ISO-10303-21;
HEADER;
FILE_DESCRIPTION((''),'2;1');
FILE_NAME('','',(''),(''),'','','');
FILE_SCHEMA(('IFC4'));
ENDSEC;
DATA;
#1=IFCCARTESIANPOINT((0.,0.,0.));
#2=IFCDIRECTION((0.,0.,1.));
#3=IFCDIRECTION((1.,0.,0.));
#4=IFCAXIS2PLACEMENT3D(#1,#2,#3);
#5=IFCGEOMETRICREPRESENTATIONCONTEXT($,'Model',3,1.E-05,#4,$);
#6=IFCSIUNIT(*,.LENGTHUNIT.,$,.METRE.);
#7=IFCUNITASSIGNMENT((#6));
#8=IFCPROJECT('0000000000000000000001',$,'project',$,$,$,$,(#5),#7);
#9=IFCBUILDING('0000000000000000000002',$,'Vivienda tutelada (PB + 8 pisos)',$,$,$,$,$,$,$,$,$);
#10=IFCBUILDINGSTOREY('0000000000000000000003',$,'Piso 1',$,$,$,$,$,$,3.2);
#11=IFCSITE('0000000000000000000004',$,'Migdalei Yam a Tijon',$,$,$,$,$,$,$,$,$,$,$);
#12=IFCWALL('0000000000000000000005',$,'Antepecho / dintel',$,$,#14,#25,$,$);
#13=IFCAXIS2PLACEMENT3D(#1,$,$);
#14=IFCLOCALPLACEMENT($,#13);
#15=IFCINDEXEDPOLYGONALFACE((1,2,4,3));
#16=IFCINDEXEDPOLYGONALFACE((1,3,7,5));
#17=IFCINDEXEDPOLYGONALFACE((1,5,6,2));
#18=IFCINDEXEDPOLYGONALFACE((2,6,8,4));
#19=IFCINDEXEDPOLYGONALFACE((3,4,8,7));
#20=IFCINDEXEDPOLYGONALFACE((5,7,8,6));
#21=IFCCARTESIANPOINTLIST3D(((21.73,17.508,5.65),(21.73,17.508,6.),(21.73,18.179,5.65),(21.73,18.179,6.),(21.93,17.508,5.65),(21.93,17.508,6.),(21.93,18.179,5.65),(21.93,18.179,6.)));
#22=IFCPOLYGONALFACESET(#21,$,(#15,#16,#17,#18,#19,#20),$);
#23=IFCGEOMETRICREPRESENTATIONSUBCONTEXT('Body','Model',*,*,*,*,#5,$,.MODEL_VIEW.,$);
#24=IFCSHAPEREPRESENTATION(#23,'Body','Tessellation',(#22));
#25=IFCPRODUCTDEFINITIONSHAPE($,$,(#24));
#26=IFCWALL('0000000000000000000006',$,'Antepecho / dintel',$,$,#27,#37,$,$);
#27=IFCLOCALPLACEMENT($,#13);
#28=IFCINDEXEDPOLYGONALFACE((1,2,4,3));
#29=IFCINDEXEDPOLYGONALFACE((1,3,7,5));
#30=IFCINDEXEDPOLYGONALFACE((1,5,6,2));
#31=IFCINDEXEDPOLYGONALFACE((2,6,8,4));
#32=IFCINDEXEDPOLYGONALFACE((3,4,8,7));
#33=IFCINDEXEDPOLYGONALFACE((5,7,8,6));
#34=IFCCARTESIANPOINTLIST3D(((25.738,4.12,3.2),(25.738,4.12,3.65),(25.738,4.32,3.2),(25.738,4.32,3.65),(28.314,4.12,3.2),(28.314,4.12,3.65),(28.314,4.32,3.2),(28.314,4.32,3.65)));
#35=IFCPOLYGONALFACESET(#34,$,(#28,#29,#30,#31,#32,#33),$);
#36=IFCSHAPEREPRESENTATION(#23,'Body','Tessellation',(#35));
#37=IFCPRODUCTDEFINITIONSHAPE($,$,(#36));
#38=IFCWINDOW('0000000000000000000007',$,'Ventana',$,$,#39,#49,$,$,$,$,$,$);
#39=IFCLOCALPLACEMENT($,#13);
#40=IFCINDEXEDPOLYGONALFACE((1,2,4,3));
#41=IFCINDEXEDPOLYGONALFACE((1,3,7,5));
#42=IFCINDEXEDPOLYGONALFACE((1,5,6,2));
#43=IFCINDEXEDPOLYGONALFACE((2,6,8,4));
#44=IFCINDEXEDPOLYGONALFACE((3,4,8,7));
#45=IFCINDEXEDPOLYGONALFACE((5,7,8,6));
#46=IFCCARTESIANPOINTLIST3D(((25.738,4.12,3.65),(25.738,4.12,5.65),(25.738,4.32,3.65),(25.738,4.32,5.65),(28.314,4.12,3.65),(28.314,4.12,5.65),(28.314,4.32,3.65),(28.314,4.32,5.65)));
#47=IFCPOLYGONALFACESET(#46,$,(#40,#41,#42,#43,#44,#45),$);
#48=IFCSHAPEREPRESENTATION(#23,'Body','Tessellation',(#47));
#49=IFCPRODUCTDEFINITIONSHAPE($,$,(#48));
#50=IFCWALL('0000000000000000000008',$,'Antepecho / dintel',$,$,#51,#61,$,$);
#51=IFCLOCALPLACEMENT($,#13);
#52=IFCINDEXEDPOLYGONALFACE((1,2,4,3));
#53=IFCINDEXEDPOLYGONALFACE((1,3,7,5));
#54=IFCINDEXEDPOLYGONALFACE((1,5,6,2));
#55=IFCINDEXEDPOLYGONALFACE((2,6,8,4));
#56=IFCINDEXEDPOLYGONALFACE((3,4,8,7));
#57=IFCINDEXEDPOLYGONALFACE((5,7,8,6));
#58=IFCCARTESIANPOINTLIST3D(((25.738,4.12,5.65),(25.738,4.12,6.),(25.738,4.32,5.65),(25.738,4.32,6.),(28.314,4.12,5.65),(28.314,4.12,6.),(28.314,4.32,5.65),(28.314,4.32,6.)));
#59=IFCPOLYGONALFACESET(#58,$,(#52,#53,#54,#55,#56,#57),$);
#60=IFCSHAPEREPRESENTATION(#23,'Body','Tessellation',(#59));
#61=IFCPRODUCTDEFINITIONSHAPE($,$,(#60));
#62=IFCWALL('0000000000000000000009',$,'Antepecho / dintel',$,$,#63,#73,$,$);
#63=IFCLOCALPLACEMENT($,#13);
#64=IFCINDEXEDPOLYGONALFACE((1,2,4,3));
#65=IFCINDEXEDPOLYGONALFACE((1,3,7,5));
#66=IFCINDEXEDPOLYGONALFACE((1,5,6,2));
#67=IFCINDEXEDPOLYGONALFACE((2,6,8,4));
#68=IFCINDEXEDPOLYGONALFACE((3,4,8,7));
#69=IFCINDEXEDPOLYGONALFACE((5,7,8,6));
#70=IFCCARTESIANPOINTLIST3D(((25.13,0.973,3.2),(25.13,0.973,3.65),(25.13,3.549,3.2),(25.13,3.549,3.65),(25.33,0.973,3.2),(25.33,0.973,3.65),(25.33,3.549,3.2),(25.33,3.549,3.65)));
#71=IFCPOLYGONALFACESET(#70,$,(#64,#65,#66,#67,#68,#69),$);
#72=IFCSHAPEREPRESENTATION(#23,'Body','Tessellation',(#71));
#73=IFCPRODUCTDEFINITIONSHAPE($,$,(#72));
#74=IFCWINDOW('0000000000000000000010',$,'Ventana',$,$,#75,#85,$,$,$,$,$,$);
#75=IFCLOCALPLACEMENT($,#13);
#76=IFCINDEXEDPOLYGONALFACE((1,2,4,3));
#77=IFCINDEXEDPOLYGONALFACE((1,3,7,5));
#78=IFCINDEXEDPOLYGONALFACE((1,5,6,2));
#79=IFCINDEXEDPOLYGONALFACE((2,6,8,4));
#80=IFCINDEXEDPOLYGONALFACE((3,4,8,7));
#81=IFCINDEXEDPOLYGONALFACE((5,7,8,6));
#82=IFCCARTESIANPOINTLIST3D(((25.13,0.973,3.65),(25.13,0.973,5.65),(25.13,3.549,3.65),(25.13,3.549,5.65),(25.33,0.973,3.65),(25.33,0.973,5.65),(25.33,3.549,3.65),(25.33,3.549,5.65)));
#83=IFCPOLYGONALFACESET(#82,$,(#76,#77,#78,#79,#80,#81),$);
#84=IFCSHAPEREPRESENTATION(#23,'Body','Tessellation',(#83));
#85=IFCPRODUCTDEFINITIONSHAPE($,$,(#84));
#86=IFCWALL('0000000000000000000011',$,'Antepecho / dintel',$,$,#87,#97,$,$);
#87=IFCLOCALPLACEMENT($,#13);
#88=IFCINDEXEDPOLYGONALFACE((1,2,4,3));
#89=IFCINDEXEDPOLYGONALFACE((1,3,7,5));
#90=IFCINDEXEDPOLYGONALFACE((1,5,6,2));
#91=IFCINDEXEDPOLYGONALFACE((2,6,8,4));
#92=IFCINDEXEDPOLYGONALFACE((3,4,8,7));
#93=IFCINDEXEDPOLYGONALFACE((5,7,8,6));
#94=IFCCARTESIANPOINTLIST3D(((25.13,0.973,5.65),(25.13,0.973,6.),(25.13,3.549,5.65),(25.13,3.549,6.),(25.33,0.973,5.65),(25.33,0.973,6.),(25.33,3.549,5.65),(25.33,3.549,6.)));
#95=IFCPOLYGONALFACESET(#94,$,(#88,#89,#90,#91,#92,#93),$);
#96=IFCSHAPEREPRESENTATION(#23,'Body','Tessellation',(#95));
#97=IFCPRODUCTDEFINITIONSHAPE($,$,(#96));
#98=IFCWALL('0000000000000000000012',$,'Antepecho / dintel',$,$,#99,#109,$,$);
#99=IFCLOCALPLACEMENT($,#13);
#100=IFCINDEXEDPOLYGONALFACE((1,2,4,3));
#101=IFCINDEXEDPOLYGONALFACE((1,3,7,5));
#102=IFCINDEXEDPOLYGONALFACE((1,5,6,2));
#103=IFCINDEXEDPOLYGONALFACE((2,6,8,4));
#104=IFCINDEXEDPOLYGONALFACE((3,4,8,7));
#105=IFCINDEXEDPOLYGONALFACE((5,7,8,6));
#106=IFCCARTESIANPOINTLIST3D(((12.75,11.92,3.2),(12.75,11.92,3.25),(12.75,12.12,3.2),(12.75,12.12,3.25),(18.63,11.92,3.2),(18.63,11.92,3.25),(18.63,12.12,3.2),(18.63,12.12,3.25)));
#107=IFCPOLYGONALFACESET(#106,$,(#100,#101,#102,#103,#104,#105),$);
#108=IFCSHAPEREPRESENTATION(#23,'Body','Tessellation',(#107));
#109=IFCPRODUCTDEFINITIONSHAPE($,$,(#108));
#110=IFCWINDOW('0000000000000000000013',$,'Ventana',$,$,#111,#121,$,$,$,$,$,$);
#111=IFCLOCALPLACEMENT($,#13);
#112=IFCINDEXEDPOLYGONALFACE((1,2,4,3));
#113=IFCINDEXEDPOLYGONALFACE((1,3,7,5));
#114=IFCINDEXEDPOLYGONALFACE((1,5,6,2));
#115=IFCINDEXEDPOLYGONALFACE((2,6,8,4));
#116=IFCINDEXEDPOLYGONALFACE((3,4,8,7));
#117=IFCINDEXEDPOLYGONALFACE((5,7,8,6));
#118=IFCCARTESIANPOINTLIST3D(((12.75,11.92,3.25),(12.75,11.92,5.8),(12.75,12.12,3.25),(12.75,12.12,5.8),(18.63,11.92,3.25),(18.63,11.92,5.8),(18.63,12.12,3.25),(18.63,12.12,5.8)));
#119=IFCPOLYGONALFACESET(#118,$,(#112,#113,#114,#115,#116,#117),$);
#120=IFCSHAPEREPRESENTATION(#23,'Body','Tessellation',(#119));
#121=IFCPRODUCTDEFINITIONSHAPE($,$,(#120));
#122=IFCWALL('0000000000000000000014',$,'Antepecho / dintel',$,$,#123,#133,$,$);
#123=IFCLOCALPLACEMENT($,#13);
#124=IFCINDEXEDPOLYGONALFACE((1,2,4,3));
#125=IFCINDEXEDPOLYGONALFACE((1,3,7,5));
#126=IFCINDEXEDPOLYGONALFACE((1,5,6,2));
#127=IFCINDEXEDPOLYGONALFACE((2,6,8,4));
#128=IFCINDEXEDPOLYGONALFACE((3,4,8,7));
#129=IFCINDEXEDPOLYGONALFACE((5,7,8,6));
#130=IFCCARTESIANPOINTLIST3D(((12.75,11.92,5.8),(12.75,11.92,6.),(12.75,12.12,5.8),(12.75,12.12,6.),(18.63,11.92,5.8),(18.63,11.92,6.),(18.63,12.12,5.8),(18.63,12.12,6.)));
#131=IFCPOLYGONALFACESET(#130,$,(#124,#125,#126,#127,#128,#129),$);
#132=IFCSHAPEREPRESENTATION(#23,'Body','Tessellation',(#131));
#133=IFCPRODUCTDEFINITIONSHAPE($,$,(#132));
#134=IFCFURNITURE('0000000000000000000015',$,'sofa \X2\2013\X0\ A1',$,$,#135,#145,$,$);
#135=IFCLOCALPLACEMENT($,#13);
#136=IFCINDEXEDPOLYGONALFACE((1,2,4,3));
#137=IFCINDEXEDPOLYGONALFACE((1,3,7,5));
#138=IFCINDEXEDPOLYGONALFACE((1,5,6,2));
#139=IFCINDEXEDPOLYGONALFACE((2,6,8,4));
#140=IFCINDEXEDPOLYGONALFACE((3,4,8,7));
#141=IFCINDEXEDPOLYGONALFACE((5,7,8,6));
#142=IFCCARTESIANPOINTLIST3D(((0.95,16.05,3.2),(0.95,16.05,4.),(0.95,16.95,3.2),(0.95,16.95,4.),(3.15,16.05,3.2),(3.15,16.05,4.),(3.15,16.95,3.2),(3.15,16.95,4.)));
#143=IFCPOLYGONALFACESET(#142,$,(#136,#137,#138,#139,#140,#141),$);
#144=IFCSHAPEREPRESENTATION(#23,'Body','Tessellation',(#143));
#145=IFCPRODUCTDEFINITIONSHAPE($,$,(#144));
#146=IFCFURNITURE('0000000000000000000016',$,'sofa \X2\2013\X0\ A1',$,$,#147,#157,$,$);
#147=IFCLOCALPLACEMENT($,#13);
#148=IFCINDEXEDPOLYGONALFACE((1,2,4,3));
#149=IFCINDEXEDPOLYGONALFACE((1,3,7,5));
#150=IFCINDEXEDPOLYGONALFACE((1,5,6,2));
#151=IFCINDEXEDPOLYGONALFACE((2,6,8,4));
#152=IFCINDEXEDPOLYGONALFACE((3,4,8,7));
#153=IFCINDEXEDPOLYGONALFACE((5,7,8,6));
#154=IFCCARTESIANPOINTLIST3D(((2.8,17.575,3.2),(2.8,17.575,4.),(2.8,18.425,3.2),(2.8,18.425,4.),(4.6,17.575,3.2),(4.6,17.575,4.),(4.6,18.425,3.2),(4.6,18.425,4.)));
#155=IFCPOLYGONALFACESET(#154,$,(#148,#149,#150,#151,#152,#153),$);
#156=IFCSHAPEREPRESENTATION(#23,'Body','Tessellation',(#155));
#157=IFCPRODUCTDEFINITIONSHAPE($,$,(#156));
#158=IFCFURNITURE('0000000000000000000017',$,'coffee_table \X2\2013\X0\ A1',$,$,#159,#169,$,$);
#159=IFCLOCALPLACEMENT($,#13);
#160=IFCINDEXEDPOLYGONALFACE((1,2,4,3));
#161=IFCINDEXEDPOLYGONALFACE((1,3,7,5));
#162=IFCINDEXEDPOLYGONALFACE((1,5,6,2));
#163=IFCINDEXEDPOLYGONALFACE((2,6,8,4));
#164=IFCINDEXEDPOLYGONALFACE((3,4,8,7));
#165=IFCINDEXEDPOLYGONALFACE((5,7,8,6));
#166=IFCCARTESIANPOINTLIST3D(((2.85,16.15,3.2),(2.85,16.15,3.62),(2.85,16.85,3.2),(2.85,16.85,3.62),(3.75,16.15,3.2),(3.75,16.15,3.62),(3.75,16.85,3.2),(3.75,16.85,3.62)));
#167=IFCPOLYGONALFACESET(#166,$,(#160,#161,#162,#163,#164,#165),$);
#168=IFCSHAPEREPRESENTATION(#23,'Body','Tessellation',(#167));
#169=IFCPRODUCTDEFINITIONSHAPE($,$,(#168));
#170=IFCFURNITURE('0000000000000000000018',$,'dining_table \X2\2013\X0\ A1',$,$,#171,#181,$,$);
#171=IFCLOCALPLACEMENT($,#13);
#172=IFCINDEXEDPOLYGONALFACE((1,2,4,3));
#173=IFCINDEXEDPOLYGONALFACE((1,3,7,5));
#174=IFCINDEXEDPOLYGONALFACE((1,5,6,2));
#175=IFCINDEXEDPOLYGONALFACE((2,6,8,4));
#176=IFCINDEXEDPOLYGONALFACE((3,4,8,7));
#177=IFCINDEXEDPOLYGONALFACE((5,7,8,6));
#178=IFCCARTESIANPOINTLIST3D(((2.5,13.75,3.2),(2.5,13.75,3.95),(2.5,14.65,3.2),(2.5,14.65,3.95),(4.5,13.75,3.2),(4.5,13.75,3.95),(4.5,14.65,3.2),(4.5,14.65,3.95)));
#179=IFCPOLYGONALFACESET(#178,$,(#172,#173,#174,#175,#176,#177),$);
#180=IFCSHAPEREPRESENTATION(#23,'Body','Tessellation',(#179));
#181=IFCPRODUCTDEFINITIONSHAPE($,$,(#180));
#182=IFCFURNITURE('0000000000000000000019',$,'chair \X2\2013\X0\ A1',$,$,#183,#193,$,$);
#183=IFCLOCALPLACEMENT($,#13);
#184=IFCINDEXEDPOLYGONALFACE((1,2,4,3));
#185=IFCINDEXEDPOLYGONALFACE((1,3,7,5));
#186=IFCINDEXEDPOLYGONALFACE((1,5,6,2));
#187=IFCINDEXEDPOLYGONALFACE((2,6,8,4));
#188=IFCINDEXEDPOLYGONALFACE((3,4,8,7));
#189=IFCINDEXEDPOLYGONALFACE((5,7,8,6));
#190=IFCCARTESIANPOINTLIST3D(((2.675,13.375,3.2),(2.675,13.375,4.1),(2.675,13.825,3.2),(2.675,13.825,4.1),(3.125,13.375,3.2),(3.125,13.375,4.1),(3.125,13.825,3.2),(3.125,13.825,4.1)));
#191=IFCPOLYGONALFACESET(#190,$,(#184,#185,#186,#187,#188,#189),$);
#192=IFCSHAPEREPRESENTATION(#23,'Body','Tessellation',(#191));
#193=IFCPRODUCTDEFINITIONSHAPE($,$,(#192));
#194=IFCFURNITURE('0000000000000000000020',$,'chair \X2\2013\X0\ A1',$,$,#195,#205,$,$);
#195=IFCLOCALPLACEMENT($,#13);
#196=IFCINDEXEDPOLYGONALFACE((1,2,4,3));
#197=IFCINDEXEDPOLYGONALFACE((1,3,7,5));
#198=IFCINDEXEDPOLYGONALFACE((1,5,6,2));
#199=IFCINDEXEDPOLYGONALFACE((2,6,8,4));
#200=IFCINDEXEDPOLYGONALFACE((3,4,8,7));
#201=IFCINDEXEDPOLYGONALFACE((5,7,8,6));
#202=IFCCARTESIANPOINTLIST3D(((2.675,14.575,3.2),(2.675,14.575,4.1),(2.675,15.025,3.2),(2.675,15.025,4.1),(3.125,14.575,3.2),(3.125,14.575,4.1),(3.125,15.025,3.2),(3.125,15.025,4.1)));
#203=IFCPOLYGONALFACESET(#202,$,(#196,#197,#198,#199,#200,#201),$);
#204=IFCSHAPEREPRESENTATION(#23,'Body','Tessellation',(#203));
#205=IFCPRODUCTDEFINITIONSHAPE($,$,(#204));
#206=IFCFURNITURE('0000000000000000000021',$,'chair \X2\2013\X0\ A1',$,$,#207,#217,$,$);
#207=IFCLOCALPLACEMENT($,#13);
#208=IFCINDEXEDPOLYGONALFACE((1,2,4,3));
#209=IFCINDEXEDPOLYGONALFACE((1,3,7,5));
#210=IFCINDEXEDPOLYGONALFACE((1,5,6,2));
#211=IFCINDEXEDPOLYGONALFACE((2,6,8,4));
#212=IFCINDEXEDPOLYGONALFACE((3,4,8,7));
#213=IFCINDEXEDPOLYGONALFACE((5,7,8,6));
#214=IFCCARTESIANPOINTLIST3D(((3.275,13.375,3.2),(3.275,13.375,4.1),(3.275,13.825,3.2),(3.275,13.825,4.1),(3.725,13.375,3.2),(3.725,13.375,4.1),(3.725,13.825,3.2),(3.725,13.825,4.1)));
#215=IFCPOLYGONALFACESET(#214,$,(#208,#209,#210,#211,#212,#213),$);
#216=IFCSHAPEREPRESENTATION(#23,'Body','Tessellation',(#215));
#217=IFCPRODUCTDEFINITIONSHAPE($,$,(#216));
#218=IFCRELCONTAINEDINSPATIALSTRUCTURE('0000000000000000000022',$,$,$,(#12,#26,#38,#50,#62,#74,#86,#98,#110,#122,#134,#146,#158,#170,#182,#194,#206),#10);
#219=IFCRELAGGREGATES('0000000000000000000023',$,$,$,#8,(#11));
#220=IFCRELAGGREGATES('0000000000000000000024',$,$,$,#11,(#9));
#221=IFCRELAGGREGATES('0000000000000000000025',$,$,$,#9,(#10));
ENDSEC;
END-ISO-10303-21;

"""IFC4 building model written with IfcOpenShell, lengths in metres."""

from ifc_helpers import new_model, si_unit, frame, origin_with_axes, context, subcontext, project, spatial, line, indexed_curve, outline, extrude, element, save


model = new_model("IFC4")

# Units and contexts
model_context = context("Model", 3, precision=1e-05, world=origin_with_axes())
body_context = subcontext(model_context, "Body", "Model", "MODEL_VIEW")
ifc_project = project(units=[si_unit("LENGTHUNIT", "METRE")], contexts=[model_context])

# Site, building, storey
site = spatial("IfcSite", under=ifc_project, Name="Migdalei Yam a Tijon")
building = spatial("IfcBuilding", under=site, Name="Vivienda tutelada (PB + 8 pisos)")
storey = spatial("IfcBuildingStorey", under=building, Name="Piso 1", Elevation=3.2)

# Walls
element("IfcWall", 1, inside=storey, Name="Antepecho / dintel", context=body_context, shape_type="SweptSolid", body=[
    extrude(outline(indexed_curve([(0.0, 0.0), (0.2, 0.0), (0.2, 0.671), (0.0, 0.671)], segments=[line(1, 2, 3, 4, 1)])), frame((21.73, 17.508, 5.65), z_axis=(0.0, 0.0, 1.0), x_axis=(1.0, 0.0, 0.0)), (0.0, 0.0, 1.0), 0.35),
])
element("IfcWall", 2, inside=storey, Name="Antepecho / dintel", context=body_context, shape_type="SweptSolid", body=[
    extrude(outline(indexed_curve([(0.0, 0.0), (2.576, 0.0), (2.576, 0.2), (0.0, 0.2)], segments=[line(1, 2, 3, 4, 1)])), frame((25.738, 4.12, 3.2), z_axis=(0.0, 0.0, 1.0), x_axis=(1.0, 0.0, 0.0)), (0.0, 0.0, 1.0), 0.45),
])

# Window
element("IfcWindow", 3, inside=storey, Name="Ventana", context=body_context, shape_type="SweptSolid", body=[
    extrude(outline(indexed_curve([(0.0, 0.0), (2.576, 0.0), (2.576, 0.2), (0.0, 0.2)], segments=[line(1, 2, 3, 4, 1)])), frame((25.738, 4.12, 3.65), z_axis=(0.0, 0.0, 1.0), x_axis=(1.0, 0.0, 0.0)), (0.0, 0.0, 1.0), 2.0),
])

# Walls
element("IfcWall", 4, inside=storey, Name="Antepecho / dintel", context=body_context, shape_type="SweptSolid", body=[
    extrude(outline(indexed_curve([(0.0, 0.0), (2.576, 0.0), (2.576, 0.2), (0.0, 0.2)], segments=[line(1, 2, 3, 4, 1)])), frame((25.738, 4.12, 5.65), z_axis=(0.0, 0.0, 1.0), x_axis=(1.0, 0.0, 0.0)), (0.0, 0.0, 1.0), 0.35),
])
element("IfcWall", 5, inside=storey, Name="Antepecho / dintel", context=body_context, shape_type="SweptSolid", body=[
    extrude(outline(indexed_curve([(0.0, 0.0), (0.2, 0.0), (0.2, 2.576), (0.0, 2.576)], segments=[line(1, 2, 3, 4, 1)])), frame((25.13, 0.973, 3.2), z_axis=(0.0, 0.0, 1.0), x_axis=(1.0, 0.0, 0.0)), (0.0, 0.0, 1.0), 0.45),
])

# Window
element("IfcWindow", 6, inside=storey, Name="Ventana", context=body_context, shape_type="SweptSolid", body=[
    extrude(outline(indexed_curve([(0.0, 0.0), (0.2, 0.0), (0.2, 2.576), (0.0, 2.576)], segments=[line(1, 2, 3, 4, 1)])), frame((25.13, 0.973, 3.65), z_axis=(0.0, 0.0, 1.0), x_axis=(1.0, 0.0, 0.0)), (0.0, 0.0, 1.0), 2.0),
])

# Walls
element("IfcWall", 7, inside=storey, Name="Antepecho / dintel", context=body_context, shape_type="SweptSolid", body=[
    extrude(outline(indexed_curve([(0.0, 0.0), (0.2, 0.0), (0.2, 2.576), (0.0, 2.576)], segments=[line(1, 2, 3, 4, 1)])), frame((25.13, 0.973, 5.65), z_axis=(0.0, 0.0, 1.0), x_axis=(1.0, 0.0, 0.0)), (0.0, 0.0, 1.0), 0.35),
])
element("IfcWall", 8, inside=storey, Name="Antepecho / dintel", context=body_context, shape_type="SweptSolid", body=[
    extrude(outline(indexed_curve([(0.0, 0.0), (5.88, 0.0), (5.88, 0.2), (0.0, 0.2)], segments=[line(1, 2, 3, 4, 1)])), frame((12.75, 11.92, 3.2), z_axis=(0.0, 0.0, 1.0), x_axis=(1.0, 0.0, 0.0)), (0.0, 0.0, 1.0), 0.05),
])

# Window
element("IfcWindow", 9, inside=storey, Name="Ventana", context=body_context, shape_type="SweptSolid", body=[
    extrude(outline(indexed_curve([(0.0, 0.0), (5.88, 0.0), (5.88, 0.2), (0.0, 0.2)], segments=[line(1, 2, 3, 4, 1)])), frame((12.75, 11.92, 3.25), z_axis=(0.0, 0.0, 1.0), x_axis=(1.0, 0.0, 0.0)), (0.0, 0.0, 1.0), 2.55),
])

# Wall
element("IfcWall", 10, inside=storey, Name="Antepecho / dintel", context=body_context, shape_type="SweptSolid", body=[
    extrude(outline(indexed_curve([(0.0, 0.0), (5.88, 0.0), (5.88, 0.2), (0.0, 0.2)], segments=[line(1, 2, 3, 4, 1)])), frame((12.75, 11.92, 5.8), z_axis=(0.0, 0.0, 1.0), x_axis=(1.0, 0.0, 0.0)), (0.0, 0.0, 1.0), 0.2),
])

# Furniture
element("IfcFurniture", 11, inside=storey, Name="sofa – A1", context=body_context, shape_type="SweptSolid", body=[
    extrude(outline(indexed_curve([(0.0, 0.0), (2.2, 0.0), (2.2, 0.9), (0.0, 0.9)], segments=[line(1, 2, 3, 4, 1)])), frame((0.95, 16.05, 3.2), z_axis=(0.0, 0.0, 1.0), x_axis=(1.0, 0.0, 0.0)), (0.0, 0.0, 1.0), 0.8),
])
element("IfcFurniture", 12, inside=storey, Name="sofa – A1", context=body_context, shape_type="SweptSolid", body=[
    extrude(outline(indexed_curve([(0.0, 0.0), (1.8, 0.0), (1.8, 0.85), (0.0, 0.85)], segments=[line(1, 2, 3, 4, 1)])), frame((2.8, 17.575, 3.2), z_axis=(0.0, 0.0, 1.0), x_axis=(1.0, 0.0, 0.0)), (0.0, 0.0, 1.0), 0.8),
])
element("IfcFurniture", 13, inside=storey, Name="coffee_table – A1", context=body_context, shape_type="SweptSolid", body=[
    extrude(outline(indexed_curve([(0.0, 0.0), (0.9, 0.0), (0.9, 0.7), (0.0, 0.7)], segments=[line(1, 2, 3, 4, 1)])), frame((2.85, 16.15, 3.2), z_axis=(0.0, 0.0, 1.0), x_axis=(1.0, 0.0, 0.0)), (0.0, 0.0, 1.0), 0.42),
])
element("IfcFurniture", 14, inside=storey, Name="dining_table – A1", context=body_context, shape_type="SweptSolid", body=[
    extrude(outline(indexed_curve([(0.0, 0.0), (2.0, 0.0), (2.0, 0.9), (0.0, 0.9)], segments=[line(1, 2, 3, 4, 1)])), frame((2.5, 13.75, 3.2), z_axis=(0.0, 0.0, 1.0), x_axis=(1.0, 0.0, 0.0)), (0.0, 0.0, 1.0), 0.75),
])
element("IfcFurniture", 15, inside=storey, Name="chair – A1", context=body_context, shape_type="SweptSolid", body=[
    extrude(outline(indexed_curve([(0.0, 0.0), (0.45, 0.0), (0.45, 0.45), (0.0, 0.45)], segments=[line(1, 2, 3, 4, 1)])), frame((2.675, 13.375, 3.2), z_axis=(0.0, 0.0, 1.0), x_axis=(1.0, 0.0, 0.0)), (0.0, 0.0, 1.0), 0.9),
])
element("IfcFurniture", 16, inside=storey, Name="chair – A1", context=body_context, shape_type="SweptSolid", body=[
    extrude(outline(indexed_curve([(0.0, 0.0), (0.45, 0.0), (0.45, 0.45), (0.0, 0.45)], segments=[line(1, 2, 3, 4, 1)])), frame((2.675, 14.575, 3.2), z_axis=(0.0, 0.0, 1.0), x_axis=(1.0, 0.0, 0.0)), (0.0, 0.0, 1.0), 0.9),
])
element("IfcFurniture", 17, inside=storey, Name="chair – A1", context=body_context, shape_type="SweptSolid", body=[
    extrude(outline(indexed_curve([(0.0, 0.0), (0.45, 0.0), (0.45, 0.45), (0.0, 0.45)], segments=[line(1, 2, 3, 4, 1)])), frame((3.275, 13.375, 3.2), z_axis=(0.0, 0.0, 1.0), x_axis=(1.0, 0.0, 0.0)), (0.0, 0.0, 1.0), 0.9),
])

save(model, "model.ifc")
